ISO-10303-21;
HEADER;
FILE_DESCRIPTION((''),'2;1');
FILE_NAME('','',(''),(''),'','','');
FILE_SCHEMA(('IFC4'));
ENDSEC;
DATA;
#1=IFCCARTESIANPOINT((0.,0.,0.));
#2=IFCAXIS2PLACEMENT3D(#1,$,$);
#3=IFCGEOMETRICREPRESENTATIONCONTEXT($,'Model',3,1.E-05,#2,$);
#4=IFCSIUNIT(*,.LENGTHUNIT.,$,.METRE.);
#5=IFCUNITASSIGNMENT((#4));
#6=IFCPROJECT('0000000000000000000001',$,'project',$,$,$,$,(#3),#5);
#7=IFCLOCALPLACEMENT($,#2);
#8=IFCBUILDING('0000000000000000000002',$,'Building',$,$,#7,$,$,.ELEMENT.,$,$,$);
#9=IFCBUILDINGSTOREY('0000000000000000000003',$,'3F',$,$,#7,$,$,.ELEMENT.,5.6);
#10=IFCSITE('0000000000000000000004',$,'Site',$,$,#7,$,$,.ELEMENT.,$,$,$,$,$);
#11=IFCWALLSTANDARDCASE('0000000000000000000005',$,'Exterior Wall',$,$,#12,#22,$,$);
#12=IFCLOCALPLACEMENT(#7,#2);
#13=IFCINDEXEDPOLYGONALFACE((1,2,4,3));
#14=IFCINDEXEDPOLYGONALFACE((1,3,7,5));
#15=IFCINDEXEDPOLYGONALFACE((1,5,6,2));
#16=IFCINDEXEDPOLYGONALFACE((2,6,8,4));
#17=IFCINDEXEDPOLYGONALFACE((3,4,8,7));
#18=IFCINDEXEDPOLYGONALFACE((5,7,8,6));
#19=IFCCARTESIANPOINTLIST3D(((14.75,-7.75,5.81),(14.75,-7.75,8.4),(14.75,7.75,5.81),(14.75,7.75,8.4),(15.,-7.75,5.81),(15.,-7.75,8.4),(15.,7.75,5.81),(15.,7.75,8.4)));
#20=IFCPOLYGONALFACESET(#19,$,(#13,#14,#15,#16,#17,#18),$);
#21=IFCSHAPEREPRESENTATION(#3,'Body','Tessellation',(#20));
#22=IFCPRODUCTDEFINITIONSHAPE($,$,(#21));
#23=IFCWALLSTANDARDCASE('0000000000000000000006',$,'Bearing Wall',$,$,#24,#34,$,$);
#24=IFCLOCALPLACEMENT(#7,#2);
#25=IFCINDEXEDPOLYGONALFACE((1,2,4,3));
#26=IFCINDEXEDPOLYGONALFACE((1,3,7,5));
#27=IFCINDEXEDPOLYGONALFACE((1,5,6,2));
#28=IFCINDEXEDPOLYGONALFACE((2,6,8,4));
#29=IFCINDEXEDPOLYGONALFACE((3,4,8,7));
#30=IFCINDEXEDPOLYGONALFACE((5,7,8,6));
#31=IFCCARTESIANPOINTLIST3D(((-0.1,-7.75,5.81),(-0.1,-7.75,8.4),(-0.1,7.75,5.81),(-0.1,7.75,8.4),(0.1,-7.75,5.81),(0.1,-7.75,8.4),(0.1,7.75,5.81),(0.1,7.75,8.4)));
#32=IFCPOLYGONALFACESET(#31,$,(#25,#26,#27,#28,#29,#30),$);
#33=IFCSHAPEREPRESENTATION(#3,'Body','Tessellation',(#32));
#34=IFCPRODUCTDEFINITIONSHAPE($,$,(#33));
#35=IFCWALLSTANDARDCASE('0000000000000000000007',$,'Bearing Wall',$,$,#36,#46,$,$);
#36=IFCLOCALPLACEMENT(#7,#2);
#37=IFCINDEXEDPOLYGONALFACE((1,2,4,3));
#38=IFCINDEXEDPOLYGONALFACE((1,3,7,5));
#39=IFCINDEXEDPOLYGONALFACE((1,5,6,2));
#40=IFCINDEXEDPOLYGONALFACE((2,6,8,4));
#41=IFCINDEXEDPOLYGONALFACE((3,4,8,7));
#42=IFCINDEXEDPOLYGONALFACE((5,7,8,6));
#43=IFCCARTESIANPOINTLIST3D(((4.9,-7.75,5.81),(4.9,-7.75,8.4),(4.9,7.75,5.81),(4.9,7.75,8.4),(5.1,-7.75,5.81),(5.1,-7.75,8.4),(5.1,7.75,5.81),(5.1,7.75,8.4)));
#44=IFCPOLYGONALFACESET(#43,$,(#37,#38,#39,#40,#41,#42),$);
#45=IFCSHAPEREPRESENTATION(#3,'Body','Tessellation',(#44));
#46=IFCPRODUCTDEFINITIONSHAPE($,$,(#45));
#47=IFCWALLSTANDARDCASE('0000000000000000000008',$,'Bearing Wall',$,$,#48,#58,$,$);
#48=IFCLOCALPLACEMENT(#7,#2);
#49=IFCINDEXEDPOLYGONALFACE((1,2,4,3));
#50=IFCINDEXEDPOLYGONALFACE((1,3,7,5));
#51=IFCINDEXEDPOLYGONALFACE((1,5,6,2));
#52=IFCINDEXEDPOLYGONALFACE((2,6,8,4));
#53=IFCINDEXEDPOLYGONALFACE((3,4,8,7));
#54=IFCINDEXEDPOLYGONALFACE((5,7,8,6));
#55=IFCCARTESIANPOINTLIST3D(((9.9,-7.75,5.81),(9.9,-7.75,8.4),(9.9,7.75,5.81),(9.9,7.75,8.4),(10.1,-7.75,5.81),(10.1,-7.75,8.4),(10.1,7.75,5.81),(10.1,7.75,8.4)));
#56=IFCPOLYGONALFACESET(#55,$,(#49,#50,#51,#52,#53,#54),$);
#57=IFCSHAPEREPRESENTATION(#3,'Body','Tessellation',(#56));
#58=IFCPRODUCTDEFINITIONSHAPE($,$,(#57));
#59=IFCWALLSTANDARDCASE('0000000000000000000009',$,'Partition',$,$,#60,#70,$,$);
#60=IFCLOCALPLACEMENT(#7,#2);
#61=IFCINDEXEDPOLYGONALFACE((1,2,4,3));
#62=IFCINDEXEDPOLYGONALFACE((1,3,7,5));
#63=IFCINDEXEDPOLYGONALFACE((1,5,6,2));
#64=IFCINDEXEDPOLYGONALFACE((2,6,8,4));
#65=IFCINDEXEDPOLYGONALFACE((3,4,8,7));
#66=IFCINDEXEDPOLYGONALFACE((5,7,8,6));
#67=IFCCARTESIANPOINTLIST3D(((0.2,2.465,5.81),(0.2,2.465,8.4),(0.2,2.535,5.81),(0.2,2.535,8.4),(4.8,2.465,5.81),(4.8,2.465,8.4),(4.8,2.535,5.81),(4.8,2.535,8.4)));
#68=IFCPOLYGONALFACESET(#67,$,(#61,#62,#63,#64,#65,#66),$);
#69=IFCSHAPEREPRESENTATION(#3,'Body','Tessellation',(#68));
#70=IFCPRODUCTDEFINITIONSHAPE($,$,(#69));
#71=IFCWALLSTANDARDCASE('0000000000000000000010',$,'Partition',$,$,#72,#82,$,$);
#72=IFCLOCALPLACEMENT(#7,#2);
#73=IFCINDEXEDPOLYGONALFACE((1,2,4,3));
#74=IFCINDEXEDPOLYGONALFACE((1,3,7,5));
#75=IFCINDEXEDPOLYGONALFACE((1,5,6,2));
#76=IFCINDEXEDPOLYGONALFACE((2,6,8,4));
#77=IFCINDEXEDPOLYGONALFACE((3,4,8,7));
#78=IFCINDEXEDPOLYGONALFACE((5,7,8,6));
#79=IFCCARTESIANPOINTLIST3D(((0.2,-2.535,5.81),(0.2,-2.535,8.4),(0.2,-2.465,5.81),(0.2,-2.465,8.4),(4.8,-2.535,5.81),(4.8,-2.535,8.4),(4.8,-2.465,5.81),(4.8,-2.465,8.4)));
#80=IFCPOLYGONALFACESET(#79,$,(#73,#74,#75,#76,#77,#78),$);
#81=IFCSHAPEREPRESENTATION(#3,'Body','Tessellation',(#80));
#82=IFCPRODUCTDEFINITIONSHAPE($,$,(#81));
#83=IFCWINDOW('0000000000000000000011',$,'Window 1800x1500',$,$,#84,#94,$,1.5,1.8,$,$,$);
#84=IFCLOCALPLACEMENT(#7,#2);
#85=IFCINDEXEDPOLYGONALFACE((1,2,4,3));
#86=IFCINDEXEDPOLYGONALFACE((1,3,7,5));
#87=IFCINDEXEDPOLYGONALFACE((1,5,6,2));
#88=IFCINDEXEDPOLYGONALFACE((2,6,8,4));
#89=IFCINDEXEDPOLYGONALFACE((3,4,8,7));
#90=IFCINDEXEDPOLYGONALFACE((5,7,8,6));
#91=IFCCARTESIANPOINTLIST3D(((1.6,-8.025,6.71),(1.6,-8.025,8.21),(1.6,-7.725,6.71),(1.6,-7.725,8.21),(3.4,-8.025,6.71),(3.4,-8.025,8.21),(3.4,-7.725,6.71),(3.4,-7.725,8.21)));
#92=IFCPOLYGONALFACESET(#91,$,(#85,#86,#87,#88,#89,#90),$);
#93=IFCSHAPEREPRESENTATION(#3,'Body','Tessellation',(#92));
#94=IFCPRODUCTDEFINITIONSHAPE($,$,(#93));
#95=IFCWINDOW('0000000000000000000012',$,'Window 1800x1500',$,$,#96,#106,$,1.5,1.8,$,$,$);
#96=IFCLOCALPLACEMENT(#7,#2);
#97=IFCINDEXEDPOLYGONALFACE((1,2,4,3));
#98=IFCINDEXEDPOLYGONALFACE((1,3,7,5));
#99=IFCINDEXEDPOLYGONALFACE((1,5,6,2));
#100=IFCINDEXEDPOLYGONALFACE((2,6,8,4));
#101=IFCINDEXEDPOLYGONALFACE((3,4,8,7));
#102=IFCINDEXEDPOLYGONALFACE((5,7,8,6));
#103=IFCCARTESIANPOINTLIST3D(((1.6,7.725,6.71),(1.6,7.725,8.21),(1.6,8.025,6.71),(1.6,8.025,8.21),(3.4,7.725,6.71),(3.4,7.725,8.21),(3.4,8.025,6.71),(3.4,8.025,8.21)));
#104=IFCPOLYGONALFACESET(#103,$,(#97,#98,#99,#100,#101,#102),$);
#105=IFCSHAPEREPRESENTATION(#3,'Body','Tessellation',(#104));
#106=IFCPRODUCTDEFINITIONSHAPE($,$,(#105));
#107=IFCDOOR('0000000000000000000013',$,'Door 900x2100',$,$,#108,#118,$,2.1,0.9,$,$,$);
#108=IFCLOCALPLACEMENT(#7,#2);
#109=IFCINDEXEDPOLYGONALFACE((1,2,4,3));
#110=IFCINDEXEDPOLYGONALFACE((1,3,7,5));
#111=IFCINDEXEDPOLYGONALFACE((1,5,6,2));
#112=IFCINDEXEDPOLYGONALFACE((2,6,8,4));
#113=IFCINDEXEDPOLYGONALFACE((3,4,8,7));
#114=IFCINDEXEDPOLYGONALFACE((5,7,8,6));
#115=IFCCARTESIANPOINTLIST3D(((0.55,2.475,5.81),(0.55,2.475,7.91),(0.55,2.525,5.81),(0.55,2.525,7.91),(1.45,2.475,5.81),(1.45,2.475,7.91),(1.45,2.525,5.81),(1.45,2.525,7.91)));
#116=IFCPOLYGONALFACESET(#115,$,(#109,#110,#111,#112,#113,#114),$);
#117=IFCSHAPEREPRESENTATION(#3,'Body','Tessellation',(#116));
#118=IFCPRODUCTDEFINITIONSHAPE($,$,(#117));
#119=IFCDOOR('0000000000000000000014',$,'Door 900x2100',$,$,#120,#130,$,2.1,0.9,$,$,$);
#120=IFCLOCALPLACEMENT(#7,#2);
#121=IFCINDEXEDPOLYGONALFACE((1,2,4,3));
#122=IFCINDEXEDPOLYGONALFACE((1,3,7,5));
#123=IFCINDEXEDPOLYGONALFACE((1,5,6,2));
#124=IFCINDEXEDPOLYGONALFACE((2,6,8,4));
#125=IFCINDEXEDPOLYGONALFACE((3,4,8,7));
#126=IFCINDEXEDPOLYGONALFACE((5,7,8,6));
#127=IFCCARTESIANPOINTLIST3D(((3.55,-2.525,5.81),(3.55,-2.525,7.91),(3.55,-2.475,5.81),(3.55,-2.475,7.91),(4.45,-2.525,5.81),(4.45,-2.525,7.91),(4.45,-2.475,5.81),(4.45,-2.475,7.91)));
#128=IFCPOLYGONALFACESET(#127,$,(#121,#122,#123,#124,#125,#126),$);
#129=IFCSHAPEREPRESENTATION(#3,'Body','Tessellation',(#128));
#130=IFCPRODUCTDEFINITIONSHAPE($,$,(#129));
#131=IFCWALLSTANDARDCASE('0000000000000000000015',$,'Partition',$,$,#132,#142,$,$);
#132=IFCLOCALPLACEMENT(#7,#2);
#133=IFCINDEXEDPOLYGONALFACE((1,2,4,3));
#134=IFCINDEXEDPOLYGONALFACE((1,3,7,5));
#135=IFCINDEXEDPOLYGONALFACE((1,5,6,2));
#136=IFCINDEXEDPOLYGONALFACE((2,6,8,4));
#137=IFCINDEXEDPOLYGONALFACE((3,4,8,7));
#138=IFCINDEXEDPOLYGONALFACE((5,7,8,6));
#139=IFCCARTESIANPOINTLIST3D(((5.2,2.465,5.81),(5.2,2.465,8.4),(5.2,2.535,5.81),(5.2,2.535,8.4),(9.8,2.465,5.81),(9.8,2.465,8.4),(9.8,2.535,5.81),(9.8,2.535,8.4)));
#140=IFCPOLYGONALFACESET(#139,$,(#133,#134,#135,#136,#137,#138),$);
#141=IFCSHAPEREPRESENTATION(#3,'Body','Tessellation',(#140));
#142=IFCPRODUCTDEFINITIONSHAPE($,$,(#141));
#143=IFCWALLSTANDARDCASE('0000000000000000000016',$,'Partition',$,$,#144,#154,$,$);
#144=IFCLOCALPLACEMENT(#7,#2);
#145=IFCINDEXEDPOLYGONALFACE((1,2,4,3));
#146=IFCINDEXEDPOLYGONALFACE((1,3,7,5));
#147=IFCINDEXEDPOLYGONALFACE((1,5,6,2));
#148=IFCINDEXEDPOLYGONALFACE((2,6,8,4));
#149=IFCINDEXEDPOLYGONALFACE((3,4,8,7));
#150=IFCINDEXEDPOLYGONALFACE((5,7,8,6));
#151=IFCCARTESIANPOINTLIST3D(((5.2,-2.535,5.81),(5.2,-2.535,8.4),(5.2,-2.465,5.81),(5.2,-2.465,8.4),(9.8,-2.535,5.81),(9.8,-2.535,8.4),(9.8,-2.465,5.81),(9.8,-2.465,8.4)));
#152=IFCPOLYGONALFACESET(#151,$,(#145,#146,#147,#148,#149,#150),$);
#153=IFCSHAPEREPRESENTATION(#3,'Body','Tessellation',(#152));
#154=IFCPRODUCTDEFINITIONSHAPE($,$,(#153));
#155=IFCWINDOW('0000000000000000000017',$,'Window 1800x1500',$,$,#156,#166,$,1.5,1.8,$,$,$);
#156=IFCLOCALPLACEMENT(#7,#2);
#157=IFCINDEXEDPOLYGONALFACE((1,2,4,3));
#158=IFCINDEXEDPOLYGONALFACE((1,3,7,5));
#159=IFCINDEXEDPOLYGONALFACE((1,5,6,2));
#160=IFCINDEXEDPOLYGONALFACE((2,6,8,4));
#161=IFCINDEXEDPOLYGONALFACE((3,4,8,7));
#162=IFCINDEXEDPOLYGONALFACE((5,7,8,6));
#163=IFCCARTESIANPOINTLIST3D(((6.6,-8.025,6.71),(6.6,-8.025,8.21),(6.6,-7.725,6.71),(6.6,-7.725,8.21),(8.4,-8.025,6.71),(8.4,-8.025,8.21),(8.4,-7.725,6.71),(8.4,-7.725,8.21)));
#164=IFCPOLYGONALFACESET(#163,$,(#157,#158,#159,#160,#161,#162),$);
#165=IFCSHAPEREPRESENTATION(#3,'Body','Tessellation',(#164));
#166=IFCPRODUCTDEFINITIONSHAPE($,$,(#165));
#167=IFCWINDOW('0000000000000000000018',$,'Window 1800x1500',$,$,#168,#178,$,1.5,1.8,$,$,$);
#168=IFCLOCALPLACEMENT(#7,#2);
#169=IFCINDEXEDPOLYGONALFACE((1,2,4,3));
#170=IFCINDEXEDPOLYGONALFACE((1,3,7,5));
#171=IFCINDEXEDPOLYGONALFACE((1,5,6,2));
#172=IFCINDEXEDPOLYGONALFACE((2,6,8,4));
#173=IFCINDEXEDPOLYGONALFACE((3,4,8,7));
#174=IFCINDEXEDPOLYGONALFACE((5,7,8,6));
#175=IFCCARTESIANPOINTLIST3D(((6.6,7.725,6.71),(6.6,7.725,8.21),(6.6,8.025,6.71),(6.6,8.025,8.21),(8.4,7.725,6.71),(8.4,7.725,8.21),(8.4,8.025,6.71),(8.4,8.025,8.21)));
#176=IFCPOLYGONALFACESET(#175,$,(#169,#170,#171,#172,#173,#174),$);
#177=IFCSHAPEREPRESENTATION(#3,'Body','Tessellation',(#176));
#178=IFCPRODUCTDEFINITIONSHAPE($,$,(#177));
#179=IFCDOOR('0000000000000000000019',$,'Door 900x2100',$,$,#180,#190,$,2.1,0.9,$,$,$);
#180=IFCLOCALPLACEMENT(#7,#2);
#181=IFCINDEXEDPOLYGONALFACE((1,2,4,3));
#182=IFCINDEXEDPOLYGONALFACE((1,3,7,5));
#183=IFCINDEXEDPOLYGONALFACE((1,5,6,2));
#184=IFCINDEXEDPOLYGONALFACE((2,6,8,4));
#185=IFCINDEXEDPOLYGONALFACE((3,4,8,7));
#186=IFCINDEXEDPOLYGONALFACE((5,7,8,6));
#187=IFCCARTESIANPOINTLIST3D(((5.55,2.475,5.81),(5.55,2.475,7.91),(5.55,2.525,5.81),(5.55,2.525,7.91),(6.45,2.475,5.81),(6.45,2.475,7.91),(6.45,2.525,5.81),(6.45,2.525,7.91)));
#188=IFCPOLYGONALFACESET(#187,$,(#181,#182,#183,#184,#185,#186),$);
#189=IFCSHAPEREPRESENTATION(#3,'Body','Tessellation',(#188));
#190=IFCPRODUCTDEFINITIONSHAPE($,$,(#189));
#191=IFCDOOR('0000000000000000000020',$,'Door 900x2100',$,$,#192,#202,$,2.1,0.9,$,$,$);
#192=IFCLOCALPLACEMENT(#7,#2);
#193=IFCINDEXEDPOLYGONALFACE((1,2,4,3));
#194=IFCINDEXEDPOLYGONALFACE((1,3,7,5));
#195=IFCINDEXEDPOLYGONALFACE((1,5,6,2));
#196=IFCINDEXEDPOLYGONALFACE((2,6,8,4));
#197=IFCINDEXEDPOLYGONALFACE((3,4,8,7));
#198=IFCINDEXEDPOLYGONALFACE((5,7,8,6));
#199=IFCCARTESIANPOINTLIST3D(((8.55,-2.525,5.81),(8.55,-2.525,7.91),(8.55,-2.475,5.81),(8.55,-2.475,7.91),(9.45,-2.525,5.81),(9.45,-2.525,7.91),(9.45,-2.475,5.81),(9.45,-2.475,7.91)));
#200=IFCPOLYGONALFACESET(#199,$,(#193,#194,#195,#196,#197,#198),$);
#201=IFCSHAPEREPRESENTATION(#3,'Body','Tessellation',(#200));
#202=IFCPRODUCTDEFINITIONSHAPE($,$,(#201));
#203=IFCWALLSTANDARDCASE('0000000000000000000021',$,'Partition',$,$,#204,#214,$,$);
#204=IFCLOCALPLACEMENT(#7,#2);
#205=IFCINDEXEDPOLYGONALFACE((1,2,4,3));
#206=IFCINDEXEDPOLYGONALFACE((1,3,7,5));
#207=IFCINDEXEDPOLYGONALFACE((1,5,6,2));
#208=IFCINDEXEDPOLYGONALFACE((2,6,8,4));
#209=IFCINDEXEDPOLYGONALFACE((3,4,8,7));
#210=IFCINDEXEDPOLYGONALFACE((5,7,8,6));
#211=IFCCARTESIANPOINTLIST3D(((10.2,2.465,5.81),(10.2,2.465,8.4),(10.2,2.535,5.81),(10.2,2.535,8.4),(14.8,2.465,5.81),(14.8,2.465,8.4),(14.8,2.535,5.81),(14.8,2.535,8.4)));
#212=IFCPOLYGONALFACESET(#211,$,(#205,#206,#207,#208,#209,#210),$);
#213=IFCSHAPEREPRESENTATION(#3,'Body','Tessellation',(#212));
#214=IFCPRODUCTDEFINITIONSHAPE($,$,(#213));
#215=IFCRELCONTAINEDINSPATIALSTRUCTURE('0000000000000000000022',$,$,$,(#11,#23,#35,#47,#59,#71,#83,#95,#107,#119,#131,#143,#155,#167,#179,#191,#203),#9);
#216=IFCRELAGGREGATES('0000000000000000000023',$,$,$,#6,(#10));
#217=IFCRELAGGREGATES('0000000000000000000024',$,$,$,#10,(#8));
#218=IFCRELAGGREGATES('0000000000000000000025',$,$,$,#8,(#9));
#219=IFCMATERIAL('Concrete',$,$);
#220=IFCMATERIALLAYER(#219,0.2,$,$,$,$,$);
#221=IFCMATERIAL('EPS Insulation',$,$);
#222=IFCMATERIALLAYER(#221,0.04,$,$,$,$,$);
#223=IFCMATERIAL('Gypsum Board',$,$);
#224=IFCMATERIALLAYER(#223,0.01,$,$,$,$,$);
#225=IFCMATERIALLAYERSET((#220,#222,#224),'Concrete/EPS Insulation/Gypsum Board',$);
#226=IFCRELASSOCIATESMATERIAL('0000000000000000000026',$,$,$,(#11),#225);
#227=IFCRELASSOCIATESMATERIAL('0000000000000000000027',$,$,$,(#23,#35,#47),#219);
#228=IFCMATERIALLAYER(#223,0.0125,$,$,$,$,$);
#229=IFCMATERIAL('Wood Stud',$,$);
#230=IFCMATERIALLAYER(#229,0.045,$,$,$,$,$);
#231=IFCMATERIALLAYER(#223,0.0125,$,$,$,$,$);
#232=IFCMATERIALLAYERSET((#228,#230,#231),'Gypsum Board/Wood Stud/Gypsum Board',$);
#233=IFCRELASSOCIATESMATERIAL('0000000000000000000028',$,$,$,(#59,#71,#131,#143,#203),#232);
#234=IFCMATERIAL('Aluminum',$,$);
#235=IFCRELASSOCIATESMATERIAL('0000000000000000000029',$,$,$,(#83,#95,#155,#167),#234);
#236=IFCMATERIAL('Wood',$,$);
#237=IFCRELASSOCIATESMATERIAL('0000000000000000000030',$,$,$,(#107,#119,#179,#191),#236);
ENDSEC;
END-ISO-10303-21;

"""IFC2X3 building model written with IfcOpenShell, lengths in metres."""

from ifc_helpers import new_model, si_unit, frame, origin, origin_2d, place, context, project, spatial, rectangle, extrude, material, layer, layer_set, layer_usage, element, save


model = new_model("IFC2X3")

# Units and contexts
model_context = context("Model", 3, precision=1e-05, world=origin())
ifc_project = project(units=[si_unit("LENGTHUNIT", "METRE")], contexts=[model_context])

# Site, building, storey
placement = place(None, origin())
site = spatial("IfcSite", under=ifc_project, at=placement, Name="Site", CompositionType="ELEMENT")
building = spatial("IfcBuilding", under=site, at=placement, Name="Building", CompositionType="ELEMENT")
storey = spatial("IfcBuildingStorey", under=building, at=placement, Name="3F", CompositionType="ELEMENT", Elevation=5.6)

# Walls
ifc_material_1 = material(Name="Concrete")
ifc_layer_1 = layer(ifc_material_1, 0.2)
ifc_material_2 = material(Name="EPS Insulation")
ifc_layer_2 = layer(ifc_material_2, 0.04)
ifc_material_3 = material(Name="Gypsum Board")
ifc_layer_3 = layer(ifc_material_3, 0.01)
ifc_layer_set_1 = layer_set([ifc_layer_1, ifc_layer_2, ifc_layer_3], Name="Concrete/EPS Insulation/Gypsum Board")
ifc_layer_usage_1 = layer_usage(ifc_layer_set_1, "AXIS2", "POSITIVE", 0.0)
wall_placement = place(None, frame((14.875, 0.0, 5.81)))
element("IfcWallStandardCase", 1, at=wall_placement, inside=storey, material=ifc_layer_usage_1, Name="Exterior Wall", context=model_context, shape_type="SweptSolid", body=[
    extrude(rectangle(XDim=0.25, YDim=15.5, at=origin_2d()), origin(), (0.0, 0.0, 1.0), 2.59),
])
for number, where, name in (
    (2, (0.0, 0.0, 5.81), "Bearing Wall"),
    (3, (5.0, 0.0, 5.81), "Bearing Wall"),
    (4, (10.0, 0.0, 5.81), "Bearing Wall"),
):
    element("IfcWallStandardCase", number, at=place(None, frame(where)), inside=storey, material=ifc_material_1, Name=name, context=model_context, shape_type="SweptSolid", body=[
        extrude(rectangle(XDim=0.2, YDim=15.5, at=origin_2d()), origin(), (0.0, 0.0, 1.0), 2.59),
    ])
ifc_layer_4 = layer(ifc_material_3, 0.0125)
ifc_material_4 = material(Name="Wood Stud")
ifc_layer_5 = layer(ifc_material_4, 0.045)
ifc_layer_6 = layer(ifc_material_3, 0.0125)
ifc_layer_set_2 = layer_set([ifc_layer_4, ifc_layer_5, ifc_layer_6], Name="Gypsum Board/Wood Stud/Gypsum Board")
ifc_layer_usage_2 = layer_usage(ifc_layer_set_2, "AXIS2", "POSITIVE", 0.0)
for number, where, name in (
    (5, (2.5, 2.5, 5.81), "Partition"),
    (6, (2.5, -2.5, 5.81), "Partition"),
):
    element("IfcWallStandardCase", number, at=place(None, frame(where)), inside=storey, material=ifc_layer_usage_2, Name=name, context=model_context, shape_type="SweptSolid", body=[
        extrude(rectangle(XDim=4.6, YDim=0.07, at=origin_2d()), origin(), (0.0, 0.0, 1.0), 2.59),
    ])

# Windows
ifc_material_5 = material(Name="Aluminum")
for number, where, name in (
    (7, (2.5, -7.875, 6.71), "Window 1800x1500"),
    (8, (2.5, 7.875, 6.71), "Window 1800x1500"),
):
    element("IfcWindow", number, at=place(None, frame(where)), inside=storey, material=ifc_material_5, Name=name, OverallHeight=1.5, OverallWidth=1.8, context=model_context, shape_type="SweptSolid", body=[
        extrude(rectangle(XDim=1.8, YDim=0.3, at=origin_2d()), origin(), (0.0, 0.0, 1.0), 1.5),
    ])

# Doors
ifc_material_6 = material(Name="Wood")
for number, where, name in (
    (9, (1.0, 2.5, 5.81), "Door 900x2100"),
    (10, (4.0, -2.5, 5.81), "Door 900x2100"),
):
    element("IfcDoor", number, at=place(None, frame(where)), inside=storey, material=ifc_material_6, Name=name, OverallHeight=2.1, OverallWidth=0.9, context=model_context, shape_type="SweptSolid", body=[
        extrude(rectangle(XDim=0.9, YDim=0.05, at=origin_2d()), origin(), (0.0, 0.0, 1.0), 2.1),
    ])

# Walls
for number, where, name in (
    (11, (7.5, 2.5, 5.81), "Partition"),
    (12, (7.5, -2.5, 5.81), "Partition"),
):
    element("IfcWallStandardCase", number, at=place(None, frame(where)), inside=storey, material=ifc_layer_usage_2, Name=name, context=model_context, shape_type="SweptSolid", body=[
        extrude(rectangle(XDim=4.6, YDim=0.07, at=origin_2d()), origin(), (0.0, 0.0, 1.0), 2.59),
    ])

# Windows
for number, where, name in (
    (13, (7.5, -7.875, 6.71), "Window 1800x1500"),
    (14, (7.5, 7.875, 6.71), "Window 1800x1500"),
):
    element("IfcWindow", number, at=place(None, frame(where)), inside=storey, material=ifc_material_5, Name=name, OverallHeight=1.5, OverallWidth=1.8, context=model_context, shape_type="SweptSolid", body=[
        extrude(rectangle(XDim=1.8, YDim=0.3, at=origin_2d()), origin(), (0.0, 0.0, 1.0), 1.5),
    ])

# Doors
for number, where, name in (
    (15, (6.0, 2.5, 5.81), "Door 900x2100"),
    (16, (9.0, -2.5, 5.81), "Door 900x2100"),
):
    element("IfcDoor", number, at=place(None, frame(where)), inside=storey, material=ifc_material_6, Name=name, OverallHeight=2.1, OverallWidth=0.9, context=model_context, shape_type="SweptSolid", body=[
        extrude(rectangle(XDim=0.9, YDim=0.05, at=origin_2d()), origin(), (0.0, 0.0, 1.0), 2.1),
    ])

# Wall
for number, where, name in (
    (17, (12.5, 2.5, 5.81), "Partition"),
):
    element("IfcWallStandardCase", number, at=place(None, frame(where)), inside=storey, material=ifc_layer_usage_2, Name=name, context=model_context, shape_type="SweptSolid", body=[
        extrude(rectangle(XDim=4.6, YDim=0.07, at=origin_2d()), origin(), (0.0, 0.0, 1.0), 2.59),
    ])

save(model, "model.ifc")
